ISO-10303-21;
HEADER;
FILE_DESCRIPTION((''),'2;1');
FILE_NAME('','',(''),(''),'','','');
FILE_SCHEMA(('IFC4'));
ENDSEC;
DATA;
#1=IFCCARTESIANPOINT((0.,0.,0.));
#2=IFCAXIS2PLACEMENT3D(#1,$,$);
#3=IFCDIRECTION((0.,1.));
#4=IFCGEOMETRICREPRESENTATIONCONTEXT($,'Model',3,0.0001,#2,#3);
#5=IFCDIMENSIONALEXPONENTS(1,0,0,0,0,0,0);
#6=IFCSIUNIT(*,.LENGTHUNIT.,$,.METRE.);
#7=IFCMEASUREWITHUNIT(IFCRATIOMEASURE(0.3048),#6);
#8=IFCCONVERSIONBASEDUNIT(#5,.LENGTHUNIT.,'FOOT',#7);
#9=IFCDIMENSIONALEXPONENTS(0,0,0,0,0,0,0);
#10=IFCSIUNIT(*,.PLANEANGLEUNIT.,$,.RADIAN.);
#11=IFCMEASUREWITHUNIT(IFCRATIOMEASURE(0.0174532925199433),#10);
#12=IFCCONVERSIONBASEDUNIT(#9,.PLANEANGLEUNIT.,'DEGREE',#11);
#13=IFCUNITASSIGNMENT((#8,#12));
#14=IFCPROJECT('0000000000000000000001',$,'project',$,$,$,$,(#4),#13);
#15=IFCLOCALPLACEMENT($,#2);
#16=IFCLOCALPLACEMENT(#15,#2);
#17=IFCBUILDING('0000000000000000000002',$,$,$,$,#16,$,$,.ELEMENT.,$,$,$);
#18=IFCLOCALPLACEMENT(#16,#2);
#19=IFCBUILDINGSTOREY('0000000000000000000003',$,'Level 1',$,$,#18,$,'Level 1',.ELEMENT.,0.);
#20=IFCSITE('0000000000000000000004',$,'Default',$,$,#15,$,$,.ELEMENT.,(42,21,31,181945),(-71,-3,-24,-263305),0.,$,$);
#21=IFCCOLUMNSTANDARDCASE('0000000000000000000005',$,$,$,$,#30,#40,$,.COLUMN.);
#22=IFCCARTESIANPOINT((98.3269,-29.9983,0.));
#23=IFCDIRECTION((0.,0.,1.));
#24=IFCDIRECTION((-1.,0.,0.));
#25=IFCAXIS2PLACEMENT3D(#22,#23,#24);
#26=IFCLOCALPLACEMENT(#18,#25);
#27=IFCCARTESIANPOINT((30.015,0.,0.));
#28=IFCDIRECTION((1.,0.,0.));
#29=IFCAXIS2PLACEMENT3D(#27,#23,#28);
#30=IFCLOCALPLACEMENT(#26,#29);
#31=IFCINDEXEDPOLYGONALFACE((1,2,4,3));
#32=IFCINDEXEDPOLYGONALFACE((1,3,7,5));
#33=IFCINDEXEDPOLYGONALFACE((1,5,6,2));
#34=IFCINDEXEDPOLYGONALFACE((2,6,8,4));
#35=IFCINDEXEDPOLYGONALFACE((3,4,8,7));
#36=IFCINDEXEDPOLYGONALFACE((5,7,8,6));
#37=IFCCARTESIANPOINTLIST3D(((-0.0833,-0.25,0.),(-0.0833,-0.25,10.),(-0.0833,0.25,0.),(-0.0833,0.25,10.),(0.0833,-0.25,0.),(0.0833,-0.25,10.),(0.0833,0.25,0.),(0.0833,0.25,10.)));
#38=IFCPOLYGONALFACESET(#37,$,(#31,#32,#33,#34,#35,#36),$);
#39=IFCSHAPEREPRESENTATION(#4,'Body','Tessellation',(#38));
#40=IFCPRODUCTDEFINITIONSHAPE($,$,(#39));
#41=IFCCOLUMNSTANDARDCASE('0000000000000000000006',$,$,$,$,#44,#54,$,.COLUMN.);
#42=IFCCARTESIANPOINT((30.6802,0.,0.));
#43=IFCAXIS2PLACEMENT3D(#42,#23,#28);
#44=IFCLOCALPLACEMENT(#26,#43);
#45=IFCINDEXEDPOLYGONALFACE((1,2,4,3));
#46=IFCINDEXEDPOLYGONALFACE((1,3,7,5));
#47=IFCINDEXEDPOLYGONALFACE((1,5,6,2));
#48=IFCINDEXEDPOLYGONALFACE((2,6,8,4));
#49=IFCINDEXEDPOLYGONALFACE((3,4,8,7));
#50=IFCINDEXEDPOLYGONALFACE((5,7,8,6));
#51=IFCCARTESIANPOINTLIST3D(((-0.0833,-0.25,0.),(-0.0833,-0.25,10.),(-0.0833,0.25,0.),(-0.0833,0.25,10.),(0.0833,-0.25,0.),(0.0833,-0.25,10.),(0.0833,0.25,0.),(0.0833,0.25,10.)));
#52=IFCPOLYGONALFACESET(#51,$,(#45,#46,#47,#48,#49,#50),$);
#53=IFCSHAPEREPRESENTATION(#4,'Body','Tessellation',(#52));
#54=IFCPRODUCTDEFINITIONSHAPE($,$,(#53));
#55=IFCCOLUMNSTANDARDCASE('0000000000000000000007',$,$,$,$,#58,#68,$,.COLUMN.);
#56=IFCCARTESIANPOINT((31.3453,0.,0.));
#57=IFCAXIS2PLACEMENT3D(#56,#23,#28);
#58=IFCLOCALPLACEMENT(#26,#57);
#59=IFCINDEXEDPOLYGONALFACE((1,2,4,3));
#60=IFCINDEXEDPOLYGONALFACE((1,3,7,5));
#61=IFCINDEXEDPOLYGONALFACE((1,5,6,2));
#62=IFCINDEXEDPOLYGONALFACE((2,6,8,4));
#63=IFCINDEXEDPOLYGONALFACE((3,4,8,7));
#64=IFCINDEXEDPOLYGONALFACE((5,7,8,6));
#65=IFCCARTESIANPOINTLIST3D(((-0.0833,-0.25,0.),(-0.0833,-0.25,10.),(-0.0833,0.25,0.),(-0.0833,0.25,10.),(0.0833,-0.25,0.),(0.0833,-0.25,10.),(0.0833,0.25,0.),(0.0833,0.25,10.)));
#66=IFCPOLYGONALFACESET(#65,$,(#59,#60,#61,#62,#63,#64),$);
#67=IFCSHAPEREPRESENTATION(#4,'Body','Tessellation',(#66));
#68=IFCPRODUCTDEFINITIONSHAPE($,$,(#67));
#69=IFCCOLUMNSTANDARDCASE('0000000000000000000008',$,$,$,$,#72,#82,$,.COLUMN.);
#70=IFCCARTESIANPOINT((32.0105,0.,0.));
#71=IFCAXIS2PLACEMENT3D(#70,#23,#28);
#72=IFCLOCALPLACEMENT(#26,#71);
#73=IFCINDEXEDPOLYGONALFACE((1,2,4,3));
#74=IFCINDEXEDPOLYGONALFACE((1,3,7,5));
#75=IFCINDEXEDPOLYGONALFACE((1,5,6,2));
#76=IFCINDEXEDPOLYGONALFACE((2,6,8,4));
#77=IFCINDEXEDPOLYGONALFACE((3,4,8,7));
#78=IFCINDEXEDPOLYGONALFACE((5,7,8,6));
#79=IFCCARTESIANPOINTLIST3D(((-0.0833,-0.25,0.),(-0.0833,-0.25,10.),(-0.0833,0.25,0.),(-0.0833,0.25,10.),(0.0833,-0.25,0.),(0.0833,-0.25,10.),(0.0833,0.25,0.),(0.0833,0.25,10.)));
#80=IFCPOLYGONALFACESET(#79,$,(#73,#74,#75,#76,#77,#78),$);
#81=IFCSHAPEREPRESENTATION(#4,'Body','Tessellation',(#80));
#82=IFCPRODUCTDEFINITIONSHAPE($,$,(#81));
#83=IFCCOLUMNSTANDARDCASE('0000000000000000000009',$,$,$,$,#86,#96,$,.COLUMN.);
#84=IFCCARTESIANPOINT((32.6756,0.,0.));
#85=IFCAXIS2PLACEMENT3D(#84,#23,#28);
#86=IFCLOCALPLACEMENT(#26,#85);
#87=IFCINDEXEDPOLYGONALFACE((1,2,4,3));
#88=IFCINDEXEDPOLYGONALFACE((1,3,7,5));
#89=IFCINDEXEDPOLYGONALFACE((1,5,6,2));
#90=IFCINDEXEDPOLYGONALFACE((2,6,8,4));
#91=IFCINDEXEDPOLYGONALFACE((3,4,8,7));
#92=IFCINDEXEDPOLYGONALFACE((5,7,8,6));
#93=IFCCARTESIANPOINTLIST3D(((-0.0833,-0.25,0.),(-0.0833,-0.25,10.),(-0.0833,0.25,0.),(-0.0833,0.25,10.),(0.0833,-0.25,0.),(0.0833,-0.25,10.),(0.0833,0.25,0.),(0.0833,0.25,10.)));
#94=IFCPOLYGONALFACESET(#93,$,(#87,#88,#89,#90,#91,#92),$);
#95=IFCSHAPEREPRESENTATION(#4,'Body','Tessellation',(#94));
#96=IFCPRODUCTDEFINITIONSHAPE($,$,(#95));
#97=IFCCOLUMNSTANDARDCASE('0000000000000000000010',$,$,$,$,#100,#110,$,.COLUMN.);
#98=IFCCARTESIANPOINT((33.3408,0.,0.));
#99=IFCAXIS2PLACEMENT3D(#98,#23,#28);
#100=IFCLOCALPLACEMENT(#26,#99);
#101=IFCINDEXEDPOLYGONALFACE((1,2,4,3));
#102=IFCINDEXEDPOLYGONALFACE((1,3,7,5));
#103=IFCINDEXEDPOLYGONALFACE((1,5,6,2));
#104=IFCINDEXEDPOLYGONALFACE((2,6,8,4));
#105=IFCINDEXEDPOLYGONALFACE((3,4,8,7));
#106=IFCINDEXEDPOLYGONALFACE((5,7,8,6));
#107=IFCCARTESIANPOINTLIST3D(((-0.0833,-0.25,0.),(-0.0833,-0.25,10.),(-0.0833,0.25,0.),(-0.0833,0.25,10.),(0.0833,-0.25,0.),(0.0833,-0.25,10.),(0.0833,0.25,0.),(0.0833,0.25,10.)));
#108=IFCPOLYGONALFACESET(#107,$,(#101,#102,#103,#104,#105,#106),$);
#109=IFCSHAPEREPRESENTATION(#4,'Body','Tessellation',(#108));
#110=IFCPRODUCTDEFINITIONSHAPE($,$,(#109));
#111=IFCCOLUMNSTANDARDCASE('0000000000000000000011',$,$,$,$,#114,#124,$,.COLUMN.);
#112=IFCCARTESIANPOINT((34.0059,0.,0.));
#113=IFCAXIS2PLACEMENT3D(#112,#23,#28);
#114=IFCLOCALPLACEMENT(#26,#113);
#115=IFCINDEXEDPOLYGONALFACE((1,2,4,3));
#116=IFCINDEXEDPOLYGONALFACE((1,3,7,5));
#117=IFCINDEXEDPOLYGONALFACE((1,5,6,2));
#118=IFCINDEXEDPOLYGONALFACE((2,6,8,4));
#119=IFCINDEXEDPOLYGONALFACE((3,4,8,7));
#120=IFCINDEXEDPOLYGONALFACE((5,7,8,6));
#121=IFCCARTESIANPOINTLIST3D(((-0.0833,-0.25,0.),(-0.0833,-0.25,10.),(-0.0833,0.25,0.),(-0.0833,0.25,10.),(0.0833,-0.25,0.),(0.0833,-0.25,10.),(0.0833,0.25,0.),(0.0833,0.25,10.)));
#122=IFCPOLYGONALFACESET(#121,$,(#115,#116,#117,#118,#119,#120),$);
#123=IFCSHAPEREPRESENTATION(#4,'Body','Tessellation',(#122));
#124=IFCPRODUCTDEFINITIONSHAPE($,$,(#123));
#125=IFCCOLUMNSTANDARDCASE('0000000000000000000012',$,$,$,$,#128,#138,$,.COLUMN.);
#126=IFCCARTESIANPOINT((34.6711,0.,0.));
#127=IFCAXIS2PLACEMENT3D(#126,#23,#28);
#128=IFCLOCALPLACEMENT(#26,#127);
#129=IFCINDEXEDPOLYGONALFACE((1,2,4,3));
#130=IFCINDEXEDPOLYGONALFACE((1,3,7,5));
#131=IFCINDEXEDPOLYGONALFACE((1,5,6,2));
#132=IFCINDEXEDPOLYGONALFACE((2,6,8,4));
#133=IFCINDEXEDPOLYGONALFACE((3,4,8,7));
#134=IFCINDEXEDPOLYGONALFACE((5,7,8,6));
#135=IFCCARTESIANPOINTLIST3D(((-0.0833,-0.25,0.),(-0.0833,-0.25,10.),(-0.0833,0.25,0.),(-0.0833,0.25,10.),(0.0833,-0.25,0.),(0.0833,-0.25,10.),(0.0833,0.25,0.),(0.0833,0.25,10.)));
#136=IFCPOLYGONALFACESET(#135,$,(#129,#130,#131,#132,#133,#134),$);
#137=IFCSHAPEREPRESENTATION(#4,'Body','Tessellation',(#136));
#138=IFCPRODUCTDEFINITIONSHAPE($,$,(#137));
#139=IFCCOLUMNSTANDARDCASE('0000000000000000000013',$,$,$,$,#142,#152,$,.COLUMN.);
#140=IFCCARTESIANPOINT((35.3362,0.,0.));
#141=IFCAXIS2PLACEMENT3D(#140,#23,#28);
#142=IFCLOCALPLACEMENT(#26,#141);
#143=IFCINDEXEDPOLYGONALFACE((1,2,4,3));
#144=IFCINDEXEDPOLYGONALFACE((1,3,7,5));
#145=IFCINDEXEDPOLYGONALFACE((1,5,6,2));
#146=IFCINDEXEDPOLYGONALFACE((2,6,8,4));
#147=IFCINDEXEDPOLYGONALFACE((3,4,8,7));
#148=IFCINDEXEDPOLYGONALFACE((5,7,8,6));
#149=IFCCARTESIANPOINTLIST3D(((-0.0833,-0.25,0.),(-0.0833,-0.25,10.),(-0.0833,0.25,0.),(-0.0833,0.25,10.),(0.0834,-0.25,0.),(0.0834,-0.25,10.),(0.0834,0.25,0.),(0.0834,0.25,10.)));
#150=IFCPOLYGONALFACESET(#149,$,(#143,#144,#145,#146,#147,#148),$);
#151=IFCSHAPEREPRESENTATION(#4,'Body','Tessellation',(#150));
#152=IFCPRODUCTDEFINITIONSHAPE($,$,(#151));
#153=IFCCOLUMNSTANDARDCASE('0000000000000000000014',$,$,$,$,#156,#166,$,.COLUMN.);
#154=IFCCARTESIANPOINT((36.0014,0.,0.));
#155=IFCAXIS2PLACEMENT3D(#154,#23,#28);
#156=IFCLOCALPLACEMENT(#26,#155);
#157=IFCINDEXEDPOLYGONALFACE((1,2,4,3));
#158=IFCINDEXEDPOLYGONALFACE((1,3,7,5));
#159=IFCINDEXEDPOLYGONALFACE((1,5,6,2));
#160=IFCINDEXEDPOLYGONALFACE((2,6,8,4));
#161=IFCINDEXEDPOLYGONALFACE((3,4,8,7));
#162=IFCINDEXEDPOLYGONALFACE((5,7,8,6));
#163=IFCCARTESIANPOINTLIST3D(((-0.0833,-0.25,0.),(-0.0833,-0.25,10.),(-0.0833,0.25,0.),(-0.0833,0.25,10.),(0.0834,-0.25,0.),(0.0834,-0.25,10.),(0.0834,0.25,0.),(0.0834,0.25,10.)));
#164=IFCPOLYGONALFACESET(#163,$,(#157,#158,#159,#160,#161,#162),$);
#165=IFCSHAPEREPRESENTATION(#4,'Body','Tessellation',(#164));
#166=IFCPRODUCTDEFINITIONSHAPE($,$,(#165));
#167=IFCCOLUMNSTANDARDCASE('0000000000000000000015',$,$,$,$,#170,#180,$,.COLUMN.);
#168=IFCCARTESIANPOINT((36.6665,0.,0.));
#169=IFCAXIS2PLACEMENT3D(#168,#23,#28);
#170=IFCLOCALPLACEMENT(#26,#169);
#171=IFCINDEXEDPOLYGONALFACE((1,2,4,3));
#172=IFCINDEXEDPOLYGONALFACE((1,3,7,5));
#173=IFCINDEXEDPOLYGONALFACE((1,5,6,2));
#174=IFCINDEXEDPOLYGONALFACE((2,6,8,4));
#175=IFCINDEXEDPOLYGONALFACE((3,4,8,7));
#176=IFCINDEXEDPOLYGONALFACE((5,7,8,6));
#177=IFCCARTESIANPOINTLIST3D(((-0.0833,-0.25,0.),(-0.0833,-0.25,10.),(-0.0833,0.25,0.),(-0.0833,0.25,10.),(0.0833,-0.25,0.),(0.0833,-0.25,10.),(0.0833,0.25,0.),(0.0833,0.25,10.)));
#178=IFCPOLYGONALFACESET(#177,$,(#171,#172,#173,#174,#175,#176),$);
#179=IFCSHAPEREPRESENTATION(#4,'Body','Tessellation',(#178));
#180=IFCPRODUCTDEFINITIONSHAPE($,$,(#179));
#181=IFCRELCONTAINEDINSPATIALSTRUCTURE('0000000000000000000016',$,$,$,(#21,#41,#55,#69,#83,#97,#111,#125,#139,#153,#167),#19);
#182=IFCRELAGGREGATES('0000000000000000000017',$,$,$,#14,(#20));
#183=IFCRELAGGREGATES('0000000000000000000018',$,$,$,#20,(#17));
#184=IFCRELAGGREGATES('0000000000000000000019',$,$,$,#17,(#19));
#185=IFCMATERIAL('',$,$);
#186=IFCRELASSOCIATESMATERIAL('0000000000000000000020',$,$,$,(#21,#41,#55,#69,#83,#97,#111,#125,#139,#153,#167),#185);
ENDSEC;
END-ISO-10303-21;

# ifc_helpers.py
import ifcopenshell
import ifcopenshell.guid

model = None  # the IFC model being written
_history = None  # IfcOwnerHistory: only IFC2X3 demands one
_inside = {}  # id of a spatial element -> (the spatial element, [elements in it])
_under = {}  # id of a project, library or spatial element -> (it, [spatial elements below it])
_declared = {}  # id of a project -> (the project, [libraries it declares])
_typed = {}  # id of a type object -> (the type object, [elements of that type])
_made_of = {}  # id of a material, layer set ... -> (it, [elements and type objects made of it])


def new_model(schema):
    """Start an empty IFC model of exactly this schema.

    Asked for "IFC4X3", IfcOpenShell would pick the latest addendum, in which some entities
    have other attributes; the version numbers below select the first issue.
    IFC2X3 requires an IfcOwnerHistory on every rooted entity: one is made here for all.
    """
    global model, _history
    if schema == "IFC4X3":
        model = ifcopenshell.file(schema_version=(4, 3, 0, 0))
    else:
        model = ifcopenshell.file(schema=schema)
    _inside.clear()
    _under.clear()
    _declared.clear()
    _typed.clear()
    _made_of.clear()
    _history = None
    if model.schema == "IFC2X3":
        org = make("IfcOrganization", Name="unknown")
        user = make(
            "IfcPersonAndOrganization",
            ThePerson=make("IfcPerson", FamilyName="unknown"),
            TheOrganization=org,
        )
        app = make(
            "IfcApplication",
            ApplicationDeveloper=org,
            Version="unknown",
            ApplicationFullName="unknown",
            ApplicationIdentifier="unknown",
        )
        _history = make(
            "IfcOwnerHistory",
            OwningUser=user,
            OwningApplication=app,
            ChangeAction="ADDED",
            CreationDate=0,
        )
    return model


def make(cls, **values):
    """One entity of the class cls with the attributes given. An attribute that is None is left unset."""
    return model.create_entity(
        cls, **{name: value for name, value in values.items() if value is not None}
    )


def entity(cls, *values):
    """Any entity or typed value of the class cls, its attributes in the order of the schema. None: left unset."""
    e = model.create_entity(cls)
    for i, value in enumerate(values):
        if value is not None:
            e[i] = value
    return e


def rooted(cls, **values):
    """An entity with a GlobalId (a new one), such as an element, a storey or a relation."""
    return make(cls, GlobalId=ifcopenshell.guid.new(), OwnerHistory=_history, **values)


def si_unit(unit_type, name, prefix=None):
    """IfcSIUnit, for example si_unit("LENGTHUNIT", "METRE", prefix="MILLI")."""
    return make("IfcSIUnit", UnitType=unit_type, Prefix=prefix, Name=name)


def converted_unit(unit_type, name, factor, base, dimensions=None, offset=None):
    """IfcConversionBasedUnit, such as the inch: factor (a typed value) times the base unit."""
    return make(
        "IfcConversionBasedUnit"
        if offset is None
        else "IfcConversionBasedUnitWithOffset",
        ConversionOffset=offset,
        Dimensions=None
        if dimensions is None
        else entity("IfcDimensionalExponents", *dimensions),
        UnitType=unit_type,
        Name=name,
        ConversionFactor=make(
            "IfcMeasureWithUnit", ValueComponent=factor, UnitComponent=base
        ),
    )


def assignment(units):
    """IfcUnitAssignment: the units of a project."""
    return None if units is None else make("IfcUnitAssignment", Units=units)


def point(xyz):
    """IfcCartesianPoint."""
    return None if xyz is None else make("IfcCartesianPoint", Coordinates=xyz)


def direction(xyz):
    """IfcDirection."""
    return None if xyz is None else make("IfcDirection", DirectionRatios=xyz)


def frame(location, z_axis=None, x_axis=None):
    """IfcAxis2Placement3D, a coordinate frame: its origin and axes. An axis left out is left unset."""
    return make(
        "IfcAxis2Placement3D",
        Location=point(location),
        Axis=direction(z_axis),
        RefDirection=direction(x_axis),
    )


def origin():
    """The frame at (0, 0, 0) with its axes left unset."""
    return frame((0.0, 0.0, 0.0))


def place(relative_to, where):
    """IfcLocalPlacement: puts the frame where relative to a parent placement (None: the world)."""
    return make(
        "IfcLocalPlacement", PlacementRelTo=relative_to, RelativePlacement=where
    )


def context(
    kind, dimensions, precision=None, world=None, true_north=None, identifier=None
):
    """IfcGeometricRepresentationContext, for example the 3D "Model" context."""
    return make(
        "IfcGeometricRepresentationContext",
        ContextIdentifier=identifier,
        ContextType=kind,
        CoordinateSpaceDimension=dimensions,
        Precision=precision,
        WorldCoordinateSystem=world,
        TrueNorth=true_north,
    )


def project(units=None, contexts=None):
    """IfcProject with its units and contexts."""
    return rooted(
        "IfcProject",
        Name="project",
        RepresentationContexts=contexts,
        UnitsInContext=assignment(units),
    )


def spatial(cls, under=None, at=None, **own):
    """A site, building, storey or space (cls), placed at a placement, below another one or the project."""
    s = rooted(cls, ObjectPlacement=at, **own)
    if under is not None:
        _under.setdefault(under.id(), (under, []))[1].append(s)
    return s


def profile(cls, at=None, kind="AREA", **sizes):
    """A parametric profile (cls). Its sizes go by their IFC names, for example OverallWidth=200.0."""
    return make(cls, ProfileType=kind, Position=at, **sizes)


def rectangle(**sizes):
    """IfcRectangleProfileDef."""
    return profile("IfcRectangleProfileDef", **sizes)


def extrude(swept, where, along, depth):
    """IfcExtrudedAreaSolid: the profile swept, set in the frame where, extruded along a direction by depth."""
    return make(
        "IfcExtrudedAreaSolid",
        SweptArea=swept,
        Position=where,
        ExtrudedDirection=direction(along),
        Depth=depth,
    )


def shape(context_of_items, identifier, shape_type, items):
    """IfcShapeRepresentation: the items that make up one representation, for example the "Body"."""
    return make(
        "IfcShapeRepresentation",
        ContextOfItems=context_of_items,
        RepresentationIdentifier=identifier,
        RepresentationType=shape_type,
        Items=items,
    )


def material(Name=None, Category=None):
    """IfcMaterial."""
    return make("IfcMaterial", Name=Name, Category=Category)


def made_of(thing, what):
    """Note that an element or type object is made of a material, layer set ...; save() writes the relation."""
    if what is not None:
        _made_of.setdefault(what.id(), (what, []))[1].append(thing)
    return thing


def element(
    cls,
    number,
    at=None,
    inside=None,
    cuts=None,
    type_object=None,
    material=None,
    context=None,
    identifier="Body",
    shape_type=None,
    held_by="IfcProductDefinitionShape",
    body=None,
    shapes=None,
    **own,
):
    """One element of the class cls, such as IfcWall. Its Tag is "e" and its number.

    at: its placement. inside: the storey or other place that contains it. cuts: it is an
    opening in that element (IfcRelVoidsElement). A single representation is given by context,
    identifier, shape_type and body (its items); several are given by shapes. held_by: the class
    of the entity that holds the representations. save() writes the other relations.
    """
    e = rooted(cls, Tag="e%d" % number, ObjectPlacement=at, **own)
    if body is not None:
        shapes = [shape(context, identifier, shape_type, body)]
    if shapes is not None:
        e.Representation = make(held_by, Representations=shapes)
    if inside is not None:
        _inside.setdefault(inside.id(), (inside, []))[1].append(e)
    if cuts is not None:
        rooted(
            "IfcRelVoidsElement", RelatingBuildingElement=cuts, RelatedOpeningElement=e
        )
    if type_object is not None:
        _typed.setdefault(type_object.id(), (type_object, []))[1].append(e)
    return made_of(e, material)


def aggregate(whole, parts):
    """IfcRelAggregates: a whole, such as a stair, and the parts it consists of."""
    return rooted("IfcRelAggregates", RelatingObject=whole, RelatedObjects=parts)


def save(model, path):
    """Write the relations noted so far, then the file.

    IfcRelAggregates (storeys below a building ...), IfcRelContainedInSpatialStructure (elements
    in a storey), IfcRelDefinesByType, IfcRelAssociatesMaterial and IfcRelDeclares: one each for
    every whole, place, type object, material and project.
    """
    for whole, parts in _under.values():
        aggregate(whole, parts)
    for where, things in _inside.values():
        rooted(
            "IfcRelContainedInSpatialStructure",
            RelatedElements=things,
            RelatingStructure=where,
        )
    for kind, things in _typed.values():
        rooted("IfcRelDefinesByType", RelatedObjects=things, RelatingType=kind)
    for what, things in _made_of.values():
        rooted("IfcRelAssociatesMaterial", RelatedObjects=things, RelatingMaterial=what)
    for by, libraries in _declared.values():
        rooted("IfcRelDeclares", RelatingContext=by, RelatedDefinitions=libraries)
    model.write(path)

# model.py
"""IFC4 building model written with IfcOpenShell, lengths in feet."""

from ifc_helpers import new_model, entity, si_unit, converted_unit, direction, frame, origin, place, context, project, spatial, rectangle, extrude, material, element, save


model = new_model("IFC4")

# Units and contexts
model_context = context("Model", 3, precision=0.0001, world=origin(), true_north=direction((0.0, 1.0)))
ifc_project = project(units=[converted_unit("LENGTHUNIT", "FOOT", entity("IfcRatioMeasure", 0.3048), si_unit("LENGTHUNIT", "METRE"), dimensions=[1, 0, 0, 0, 0, 0, 0]), converted_unit("PLANEANGLEUNIT", "DEGREE", entity("IfcRatioMeasure", 0.0174532925199433), si_unit("PLANEANGLEUNIT", "RADIAN"), dimensions=[0, 0, 0, 0, 0, 0, 0])], contexts=[model_context])

# Site, building, storey
site_placement = place(None, origin())
site = spatial("IfcSite", under=ifc_project, at=site_placement, Name="Default", CompositionType="ELEMENT", RefLatitude=(42, 21, 31, 181945), RefLongitude=(-71, -3, -24, -263305), RefElevation=0.0)
building_placement = place(site_placement, origin())
building = spatial("IfcBuilding", under=site, at=building_placement, CompositionType="ELEMENT")
storey_placement = place(building_placement, origin())
storey = spatial("IfcBuildingStorey", under=building, at=storey_placement, Name="Level 1", LongName="Level 1", CompositionType="ELEMENT", Elevation=0.0)

# Columns
ifc_material = material(Name="")
placement = place(storey_placement, frame((98.3269, -29.9983, 0.0), z_axis=(0.0, 0.0, 1.0), x_axis=(-1.0, 0.0, 0.0)))
for number, where, z_axis, x_axis in (
    (1, (30.015, 0.0, 0.0), (0.0, 0.0, 1.0), (1.0, 0.0, 0.0)),
    (2, (30.6802, 0.0, 0.0), (0.0, 0.0, 1.0), (1.0, 0.0, 0.0)),
    (3, (31.3453, 0.0, 0.0), (0.0, 0.0, 1.0), (1.0, 0.0, 0.0)),
    (4, (32.0105, 0.0, 0.0), (0.0, 0.0, 1.0), (1.0, 0.0, 0.0)),
    (5, (32.6756, 0.0, 0.0), (0.0, 0.0, 1.0), (1.0, 0.0, 0.0)),
    (6, (33.3408, 0.0, 0.0), (0.0, 0.0, 1.0), (1.0, 0.0, 0.0)),
    (7, (34.0059, 0.0, 0.0), (0.0, 0.0, 1.0), (1.0, 0.0, 0.0)),
    (8, (34.6711, 0.0, 0.0), (0.0, 0.0, 1.0), (1.0, 0.0, 0.0)),
    (9, (35.3362, 0.0, 0.0), (0.0, 0.0, 1.0), (1.0, 0.0, 0.0)),
    (10, (36.0014, 0.0, 0.0), (0.0, 0.0, 1.0), (1.0, 0.0, 0.0)),
    (11, (36.6665, 0.0, 0.0), (0.0, 0.0, 1.0), (1.0, 0.0, 0.0)),
):
    element("IfcColumnStandardCase", number, at=place(placement, frame(where, z_axis=z_axis, x_axis=x_axis)), inside=storey, material=ifc_material, PredefinedType="COLUMN", context=model_context, shape_type="SweptSolid", body=[
        extrude(rectangle(XDim=0.1667, YDim=0.5), origin(), (0.0, 0.0, 1.0), 10.0),
    ])

save(model, "model.ifc")
